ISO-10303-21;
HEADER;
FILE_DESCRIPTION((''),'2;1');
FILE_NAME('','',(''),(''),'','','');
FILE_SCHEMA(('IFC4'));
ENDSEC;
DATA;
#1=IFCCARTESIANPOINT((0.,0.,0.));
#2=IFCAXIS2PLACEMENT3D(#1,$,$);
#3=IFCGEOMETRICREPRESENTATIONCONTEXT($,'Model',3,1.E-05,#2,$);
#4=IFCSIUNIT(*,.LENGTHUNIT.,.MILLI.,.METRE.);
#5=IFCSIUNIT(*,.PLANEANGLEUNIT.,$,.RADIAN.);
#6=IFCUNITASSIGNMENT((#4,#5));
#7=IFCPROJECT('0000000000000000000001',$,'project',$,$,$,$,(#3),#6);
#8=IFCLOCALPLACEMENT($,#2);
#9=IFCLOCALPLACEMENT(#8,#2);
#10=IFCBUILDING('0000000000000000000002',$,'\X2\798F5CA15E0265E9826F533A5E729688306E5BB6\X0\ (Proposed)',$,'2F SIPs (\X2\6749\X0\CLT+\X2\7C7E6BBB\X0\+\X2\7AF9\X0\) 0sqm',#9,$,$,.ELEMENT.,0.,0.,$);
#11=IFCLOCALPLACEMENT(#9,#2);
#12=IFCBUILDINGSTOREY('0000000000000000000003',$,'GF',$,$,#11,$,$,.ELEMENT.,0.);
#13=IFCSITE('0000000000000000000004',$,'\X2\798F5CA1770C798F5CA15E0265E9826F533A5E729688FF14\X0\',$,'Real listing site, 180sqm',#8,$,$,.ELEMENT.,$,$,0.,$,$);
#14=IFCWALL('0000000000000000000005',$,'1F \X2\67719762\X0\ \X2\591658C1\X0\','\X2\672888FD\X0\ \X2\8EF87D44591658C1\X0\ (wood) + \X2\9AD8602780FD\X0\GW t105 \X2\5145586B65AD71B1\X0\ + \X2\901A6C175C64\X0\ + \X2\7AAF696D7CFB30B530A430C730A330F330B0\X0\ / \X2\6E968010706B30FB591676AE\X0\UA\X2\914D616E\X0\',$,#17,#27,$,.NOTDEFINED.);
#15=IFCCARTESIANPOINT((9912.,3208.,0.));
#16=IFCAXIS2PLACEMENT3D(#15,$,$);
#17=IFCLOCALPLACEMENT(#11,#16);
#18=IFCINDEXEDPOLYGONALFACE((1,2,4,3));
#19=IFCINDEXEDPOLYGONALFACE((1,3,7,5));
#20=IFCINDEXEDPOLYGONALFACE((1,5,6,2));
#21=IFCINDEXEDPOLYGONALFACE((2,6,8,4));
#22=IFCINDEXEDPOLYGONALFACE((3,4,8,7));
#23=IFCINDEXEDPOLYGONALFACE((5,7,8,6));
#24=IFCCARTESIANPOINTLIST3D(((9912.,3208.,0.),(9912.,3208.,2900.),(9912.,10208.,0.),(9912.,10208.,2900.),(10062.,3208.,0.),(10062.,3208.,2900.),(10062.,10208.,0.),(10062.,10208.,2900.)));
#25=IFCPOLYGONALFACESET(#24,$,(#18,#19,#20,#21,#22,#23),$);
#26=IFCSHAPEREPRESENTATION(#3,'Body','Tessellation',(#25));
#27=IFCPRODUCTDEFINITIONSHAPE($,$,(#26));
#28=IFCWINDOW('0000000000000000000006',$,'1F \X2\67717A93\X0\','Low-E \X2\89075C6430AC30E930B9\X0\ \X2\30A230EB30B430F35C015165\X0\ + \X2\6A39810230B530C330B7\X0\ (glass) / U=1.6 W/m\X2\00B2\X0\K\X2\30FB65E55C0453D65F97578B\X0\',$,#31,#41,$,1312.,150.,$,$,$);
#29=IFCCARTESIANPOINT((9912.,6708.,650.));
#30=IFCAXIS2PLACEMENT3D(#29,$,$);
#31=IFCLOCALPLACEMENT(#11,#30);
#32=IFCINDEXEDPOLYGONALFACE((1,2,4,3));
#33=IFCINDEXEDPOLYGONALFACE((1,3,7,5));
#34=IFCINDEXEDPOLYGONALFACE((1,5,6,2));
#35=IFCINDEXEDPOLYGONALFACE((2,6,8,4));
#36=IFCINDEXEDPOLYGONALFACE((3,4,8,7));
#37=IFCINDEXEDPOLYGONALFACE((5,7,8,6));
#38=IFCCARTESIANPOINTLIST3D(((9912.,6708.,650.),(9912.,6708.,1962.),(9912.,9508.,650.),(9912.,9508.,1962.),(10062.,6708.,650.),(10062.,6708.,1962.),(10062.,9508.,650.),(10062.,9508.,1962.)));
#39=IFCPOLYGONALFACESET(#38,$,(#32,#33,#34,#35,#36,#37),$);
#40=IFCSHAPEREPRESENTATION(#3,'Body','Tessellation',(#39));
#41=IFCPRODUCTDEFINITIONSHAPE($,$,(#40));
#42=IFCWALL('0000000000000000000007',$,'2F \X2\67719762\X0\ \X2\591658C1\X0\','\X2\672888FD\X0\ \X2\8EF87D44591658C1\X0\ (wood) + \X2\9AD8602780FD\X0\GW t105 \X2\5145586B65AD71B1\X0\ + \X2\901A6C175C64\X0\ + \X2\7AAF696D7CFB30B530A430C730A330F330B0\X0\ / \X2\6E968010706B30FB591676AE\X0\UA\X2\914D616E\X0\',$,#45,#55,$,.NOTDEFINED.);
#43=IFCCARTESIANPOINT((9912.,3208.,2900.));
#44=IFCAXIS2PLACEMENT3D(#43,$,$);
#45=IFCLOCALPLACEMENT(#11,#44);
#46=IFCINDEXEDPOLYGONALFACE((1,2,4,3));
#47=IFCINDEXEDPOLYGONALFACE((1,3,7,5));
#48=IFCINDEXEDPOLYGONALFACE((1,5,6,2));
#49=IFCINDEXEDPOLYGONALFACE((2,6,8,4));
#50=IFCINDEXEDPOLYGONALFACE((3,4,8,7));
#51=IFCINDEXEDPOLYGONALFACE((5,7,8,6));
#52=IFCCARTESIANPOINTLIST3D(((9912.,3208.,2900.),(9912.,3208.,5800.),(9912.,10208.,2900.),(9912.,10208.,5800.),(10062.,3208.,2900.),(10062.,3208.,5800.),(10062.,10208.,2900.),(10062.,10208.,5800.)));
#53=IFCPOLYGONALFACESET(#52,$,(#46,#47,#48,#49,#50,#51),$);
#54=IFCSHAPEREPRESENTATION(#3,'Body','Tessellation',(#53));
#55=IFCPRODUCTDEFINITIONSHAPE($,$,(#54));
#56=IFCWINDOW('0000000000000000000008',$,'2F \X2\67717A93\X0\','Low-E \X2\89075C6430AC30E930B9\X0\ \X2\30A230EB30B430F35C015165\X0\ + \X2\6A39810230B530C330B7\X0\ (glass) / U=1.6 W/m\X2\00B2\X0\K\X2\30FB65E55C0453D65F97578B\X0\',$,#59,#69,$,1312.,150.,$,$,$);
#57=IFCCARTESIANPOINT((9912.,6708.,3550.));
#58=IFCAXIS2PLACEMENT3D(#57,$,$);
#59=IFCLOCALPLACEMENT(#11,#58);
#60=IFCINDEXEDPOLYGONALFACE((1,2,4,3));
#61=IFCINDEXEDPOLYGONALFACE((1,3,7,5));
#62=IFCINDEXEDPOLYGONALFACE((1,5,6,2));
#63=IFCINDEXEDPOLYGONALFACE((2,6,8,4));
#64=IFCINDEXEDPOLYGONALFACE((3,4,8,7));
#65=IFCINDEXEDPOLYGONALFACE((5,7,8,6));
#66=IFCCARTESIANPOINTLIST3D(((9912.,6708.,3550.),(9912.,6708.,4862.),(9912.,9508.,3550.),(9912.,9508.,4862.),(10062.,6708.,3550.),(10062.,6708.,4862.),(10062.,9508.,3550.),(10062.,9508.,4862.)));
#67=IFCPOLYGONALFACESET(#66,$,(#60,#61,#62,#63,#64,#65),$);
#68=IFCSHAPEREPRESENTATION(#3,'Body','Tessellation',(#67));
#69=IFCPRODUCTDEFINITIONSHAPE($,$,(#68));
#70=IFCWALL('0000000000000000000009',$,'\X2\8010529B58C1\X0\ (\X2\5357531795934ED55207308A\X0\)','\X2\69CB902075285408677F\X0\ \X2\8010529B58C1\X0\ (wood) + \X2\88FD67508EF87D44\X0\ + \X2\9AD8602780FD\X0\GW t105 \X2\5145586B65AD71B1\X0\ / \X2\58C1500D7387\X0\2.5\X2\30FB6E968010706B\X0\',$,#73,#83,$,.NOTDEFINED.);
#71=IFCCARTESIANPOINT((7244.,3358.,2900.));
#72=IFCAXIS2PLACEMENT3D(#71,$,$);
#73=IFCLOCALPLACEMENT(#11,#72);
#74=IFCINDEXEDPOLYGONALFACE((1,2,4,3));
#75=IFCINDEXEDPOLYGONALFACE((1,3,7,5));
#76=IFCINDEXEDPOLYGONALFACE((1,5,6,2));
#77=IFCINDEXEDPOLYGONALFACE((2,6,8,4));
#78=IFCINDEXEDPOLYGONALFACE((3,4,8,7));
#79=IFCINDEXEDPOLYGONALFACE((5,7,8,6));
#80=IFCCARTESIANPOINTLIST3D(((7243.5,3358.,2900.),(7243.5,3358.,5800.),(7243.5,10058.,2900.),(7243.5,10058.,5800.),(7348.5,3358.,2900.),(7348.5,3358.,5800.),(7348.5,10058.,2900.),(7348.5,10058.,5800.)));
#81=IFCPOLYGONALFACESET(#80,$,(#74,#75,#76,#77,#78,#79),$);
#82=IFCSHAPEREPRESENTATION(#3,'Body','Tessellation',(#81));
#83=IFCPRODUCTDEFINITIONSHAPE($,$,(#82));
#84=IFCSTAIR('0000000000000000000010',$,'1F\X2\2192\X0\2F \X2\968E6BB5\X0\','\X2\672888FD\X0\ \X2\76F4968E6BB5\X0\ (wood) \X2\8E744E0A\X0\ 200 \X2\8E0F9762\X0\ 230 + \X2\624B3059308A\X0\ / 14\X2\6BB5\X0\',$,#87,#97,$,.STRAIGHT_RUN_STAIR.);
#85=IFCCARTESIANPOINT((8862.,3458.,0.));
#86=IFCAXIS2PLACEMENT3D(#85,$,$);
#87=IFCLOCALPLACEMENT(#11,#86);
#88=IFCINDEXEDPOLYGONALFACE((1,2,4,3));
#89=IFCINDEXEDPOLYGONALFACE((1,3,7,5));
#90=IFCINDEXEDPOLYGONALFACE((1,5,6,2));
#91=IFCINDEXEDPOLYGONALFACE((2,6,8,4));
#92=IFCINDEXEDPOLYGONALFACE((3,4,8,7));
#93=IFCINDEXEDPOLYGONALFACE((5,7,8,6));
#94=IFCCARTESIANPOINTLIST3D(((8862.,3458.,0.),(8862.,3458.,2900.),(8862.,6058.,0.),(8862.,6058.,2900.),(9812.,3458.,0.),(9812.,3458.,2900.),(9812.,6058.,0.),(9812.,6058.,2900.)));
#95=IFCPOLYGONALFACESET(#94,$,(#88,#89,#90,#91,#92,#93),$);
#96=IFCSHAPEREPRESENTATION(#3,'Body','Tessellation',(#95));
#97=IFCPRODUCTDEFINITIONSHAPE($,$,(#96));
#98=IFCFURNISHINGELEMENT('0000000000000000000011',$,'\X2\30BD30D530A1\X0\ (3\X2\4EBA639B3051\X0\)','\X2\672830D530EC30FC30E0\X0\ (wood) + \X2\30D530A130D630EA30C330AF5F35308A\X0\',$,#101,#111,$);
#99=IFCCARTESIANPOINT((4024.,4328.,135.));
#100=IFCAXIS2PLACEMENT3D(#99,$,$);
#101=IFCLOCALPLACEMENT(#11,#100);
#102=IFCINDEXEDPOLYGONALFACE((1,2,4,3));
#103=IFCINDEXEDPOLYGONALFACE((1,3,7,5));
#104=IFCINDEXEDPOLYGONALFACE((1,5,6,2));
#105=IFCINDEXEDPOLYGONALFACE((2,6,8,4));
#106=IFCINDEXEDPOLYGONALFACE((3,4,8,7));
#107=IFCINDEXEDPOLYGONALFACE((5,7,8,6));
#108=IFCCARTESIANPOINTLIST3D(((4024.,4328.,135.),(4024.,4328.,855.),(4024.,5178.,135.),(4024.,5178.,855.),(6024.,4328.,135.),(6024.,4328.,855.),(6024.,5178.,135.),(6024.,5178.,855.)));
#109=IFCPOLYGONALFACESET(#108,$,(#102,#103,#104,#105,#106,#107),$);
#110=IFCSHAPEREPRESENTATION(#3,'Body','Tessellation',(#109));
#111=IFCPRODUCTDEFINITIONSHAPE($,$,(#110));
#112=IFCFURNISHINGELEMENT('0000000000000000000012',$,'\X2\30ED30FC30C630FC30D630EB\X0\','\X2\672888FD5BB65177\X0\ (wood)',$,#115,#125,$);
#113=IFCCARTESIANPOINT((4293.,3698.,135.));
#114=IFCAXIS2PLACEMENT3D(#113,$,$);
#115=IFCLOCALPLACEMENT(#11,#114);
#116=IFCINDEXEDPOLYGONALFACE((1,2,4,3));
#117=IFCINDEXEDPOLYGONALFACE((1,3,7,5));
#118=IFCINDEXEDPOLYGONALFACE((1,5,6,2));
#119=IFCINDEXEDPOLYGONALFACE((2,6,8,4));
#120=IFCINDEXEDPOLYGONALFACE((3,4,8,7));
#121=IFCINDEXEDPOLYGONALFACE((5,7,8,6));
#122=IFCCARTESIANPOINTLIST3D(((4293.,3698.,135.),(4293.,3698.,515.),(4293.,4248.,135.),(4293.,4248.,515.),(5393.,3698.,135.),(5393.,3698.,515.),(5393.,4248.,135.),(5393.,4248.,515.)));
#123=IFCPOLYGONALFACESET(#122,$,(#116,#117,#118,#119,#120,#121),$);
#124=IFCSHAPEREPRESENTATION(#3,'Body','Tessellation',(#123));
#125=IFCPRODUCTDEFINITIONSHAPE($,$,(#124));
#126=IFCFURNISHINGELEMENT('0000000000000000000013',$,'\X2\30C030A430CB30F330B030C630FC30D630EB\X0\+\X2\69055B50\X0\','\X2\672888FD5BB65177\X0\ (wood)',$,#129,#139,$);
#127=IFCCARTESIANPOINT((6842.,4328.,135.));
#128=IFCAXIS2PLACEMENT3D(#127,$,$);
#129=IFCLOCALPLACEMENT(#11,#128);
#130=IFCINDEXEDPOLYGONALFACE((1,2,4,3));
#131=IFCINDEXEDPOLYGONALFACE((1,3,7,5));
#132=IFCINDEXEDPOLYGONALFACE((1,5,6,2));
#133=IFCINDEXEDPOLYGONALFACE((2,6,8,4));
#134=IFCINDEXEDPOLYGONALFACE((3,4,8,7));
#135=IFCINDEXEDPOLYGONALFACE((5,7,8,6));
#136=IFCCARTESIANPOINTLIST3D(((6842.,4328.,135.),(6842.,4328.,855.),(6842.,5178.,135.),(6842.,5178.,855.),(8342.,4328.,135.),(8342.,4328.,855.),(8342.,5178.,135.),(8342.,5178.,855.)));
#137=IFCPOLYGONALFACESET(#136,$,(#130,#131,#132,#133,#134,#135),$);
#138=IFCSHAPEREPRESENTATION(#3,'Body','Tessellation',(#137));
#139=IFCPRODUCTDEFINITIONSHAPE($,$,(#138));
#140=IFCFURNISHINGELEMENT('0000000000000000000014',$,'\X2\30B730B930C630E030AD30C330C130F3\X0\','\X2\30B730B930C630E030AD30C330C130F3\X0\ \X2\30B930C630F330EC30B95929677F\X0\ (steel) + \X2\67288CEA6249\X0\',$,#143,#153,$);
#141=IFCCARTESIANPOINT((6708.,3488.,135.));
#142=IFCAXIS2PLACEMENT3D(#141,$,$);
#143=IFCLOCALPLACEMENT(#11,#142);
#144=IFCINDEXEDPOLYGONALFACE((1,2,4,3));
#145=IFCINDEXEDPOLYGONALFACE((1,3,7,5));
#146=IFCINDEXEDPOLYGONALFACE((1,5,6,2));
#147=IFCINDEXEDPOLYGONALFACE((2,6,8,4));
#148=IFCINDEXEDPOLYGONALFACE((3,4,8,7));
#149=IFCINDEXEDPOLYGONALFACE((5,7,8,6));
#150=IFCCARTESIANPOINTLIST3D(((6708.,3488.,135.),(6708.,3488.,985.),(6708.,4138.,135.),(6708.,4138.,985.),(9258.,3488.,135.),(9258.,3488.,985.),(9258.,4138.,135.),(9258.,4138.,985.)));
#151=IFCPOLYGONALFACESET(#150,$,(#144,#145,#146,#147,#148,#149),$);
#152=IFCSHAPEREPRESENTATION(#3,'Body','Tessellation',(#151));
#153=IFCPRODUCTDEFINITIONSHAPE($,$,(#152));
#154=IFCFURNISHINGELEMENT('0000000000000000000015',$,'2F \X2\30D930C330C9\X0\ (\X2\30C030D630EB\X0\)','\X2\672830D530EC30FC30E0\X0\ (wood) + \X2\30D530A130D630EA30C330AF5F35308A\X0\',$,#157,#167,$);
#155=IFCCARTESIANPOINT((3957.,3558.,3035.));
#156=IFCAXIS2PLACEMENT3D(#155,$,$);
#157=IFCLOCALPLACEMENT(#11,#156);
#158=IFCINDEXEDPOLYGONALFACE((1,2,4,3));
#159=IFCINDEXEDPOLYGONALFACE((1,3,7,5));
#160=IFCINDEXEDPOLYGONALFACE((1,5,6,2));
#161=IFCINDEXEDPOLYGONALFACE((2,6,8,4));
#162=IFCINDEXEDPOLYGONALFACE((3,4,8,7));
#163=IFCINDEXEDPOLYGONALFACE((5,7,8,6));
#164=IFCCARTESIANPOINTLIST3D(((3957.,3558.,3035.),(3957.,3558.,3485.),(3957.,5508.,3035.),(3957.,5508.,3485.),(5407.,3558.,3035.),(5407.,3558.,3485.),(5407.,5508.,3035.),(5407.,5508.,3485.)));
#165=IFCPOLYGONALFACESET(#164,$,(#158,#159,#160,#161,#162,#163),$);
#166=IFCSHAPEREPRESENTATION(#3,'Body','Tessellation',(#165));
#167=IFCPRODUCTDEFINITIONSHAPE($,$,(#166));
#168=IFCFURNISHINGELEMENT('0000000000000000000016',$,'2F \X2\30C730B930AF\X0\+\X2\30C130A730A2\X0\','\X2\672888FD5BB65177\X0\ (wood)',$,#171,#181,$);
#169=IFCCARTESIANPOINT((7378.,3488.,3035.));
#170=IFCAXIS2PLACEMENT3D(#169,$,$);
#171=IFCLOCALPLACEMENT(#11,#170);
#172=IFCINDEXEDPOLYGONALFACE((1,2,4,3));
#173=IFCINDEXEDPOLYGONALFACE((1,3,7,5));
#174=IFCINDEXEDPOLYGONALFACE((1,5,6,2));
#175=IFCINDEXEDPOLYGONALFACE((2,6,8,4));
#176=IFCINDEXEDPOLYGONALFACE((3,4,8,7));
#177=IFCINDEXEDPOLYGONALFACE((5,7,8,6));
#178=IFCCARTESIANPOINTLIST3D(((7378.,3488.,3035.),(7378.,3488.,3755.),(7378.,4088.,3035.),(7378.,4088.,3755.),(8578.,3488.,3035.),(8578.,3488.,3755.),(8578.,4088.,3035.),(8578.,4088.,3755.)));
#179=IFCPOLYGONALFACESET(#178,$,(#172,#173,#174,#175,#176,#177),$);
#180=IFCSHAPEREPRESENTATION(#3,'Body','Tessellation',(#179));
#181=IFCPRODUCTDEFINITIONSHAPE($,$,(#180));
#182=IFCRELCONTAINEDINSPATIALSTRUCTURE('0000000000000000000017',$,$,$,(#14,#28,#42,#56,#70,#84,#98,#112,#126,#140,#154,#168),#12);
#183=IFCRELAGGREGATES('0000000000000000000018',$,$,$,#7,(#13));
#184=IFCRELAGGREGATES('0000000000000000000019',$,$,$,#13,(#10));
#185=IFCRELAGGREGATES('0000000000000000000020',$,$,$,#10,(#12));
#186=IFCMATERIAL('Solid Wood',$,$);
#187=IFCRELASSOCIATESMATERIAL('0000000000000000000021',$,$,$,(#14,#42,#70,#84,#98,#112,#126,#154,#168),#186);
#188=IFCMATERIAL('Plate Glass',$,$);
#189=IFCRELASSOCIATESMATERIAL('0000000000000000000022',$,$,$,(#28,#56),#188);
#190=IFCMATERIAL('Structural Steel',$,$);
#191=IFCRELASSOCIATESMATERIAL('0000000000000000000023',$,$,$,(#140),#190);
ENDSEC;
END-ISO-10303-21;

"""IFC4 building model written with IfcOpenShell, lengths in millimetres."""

from ifc_helpers import new_model, si_unit, frame, frame_2d, origin, place, context, project, spatial, rectangle, extrude, material, element, fill, save


model = new_model("IFC4")

# Units and contexts
model_context = context("Model", 3, precision=1e-05, world=origin())
ifc_project = project(units=[si_unit("LENGTHUNIT", "METRE", prefix="MILLI"), si_unit("PLANEANGLEUNIT", "RADIAN")], contexts=[model_context])

# Site, building, storey
site_placement = place(None, origin())
site = spatial("IfcSite", under=ifc_project, at=site_placement, Name="福岡県福岡市早良区干隈４", ObjectType="Real listing site, 180sqm", CompositionType="ELEMENT", RefElevation=0.0)
building_placement = place(site_placement, origin())
building = spatial("IfcBuilding", under=site, at=building_placement, Name="福岡市早良区干隈の家 (Proposed)", ObjectType="2F SIPs (杉CLT+籾殻+竹) 0sqm", CompositionType="ELEMENT", ElevationOfRefHeight=0.0, ElevationOfTerrain=0.0)
storey_placement = place(building_placement, origin())
storey = spatial("IfcBuildingStorey", under=building, at=storey_placement, Name="GF", CompositionType="ELEMENT", Elevation=0.0)

# Wall, opening, window
ifc_material_1 = material(Name="Solid Wood")
wall_1_placement = place(storey_placement, frame((9912.0, 3208.0, 0.0)))
wall_1 = element("IfcWall", 1, at=wall_1_placement, inside=storey, material=ifc_material_1, Name="1F 東面 外壁", Description="木製 軸組外壁 (wood) + 高性能GW t105 充填断熱 + 通気層 + 窯業系サイディング / 準耐火・外皮UA配慮", PredefinedType="NOTDEFINED", context=model_context, shape_type="SweptSolid", body=[
    extrude(rectangle(XDim=150.0, YDim=7000.0, at=frame_2d((75.0, 3500.0))), frame((9912.0, 3208.0, 0.0)), (0.0, 0.0, 1.0), 2900.0),
])
opening_1_placement = place(storey_placement, frame((9912.0, 6708.0, 650.0)))
opening_1 = element("IfcOpeningElement", 2, at=opening_1_placement, cuts=wall_1, PredefinedType="NOTDEFINED", context=model_context, shape_type="SweptSolid", body=[
    extrude(rectangle(XDim=150.0, YDim=2800.0, at=frame_2d((75.0, 1400.0))), frame((9912.0, 6708.0, 650.0)), (0.0, 0.0, 1.0), 1312.0),
])
ifc_material_2 = material(Name="Plate Glass")
window_1_placement = place(storey_placement, frame((9912.0, 6708.0, 650.0)))
window_1 = element("IfcWindow", 3, at=window_1_placement, inside=storey, material=ifc_material_2, Name="1F 東窓", Description="Low-E 複層ガラス アルゴン封入 + 樹脂サッシ (glass) / U=1.6 W/m²K・日射取得型", OverallHeight=1312.0, OverallWidth=150.0, context=model_context, shape_type="SweptSolid", body=[
    extrude(rectangle(XDim=150.0, YDim=2800.0, at=frame_2d((75.0, 1400.0))), frame((9912.0, 6708.0, 650.0)), (0.0, 0.0, 1.0), 1312.0),
])
fill(opening_1, window_1)

# Wall, opening, window
wall_2_placement = place(storey_placement, frame((9912.0, 3208.0, 2900.0)))
wall_2 = element("IfcWall", 4, at=wall_2_placement, inside=storey, material=ifc_material_1, Name="2F 東面 外壁", Description="木製 軸組外壁 (wood) + 高性能GW t105 充填断熱 + 通気層 + 窯業系サイディング / 準耐火・外皮UA配慮", PredefinedType="NOTDEFINED", context=model_context, shape_type="SweptSolid", body=[
    extrude(rectangle(XDim=150.0, YDim=7000.0, at=frame_2d((75.0, 3500.0))), frame((9912.0, 3208.0, 2900.0)), (0.0, 0.0, 1.0), 2900.0),
])
opening_2_placement = place(storey_placement, frame((9912.0, 6708.0, 3550.0)))
opening_2 = element("IfcOpeningElement", 5, at=opening_2_placement, cuts=wall_2, PredefinedType="NOTDEFINED", context=model_context, shape_type="SweptSolid", body=[
    extrude(rectangle(XDim=150.0, YDim=2800.0, at=frame_2d((75.0, 1400.0))), frame((9912.0, 6708.0, 3550.0)), (0.0, 0.0, 1.0), 1312.0),
])
window_2_placement = place(storey_placement, frame((9912.0, 6708.0, 3550.0)))
window_2 = element("IfcWindow", 6, at=window_2_placement, inside=storey, material=ifc_material_2, Name="2F 東窓", Description="Low-E 複層ガラス アルゴン封入 + 樹脂サッシ (glass) / U=1.6 W/m²K・日射取得型", OverallHeight=1312.0, OverallWidth=150.0, context=model_context, shape_type="SweptSolid", body=[
    extrude(rectangle(XDim=150.0, YDim=2800.0, at=frame_2d((75.0, 1400.0))), frame((9912.0, 6708.0, 3550.0)), (0.0, 0.0, 1.0), 1312.0),
])
fill(opening_2, window_2)

# Wall
wall_3_placement = place(storey_placement, frame((7244.0, 3358.0, 2900.0)))
element("IfcWall", 7, at=wall_3_placement, inside=storey, material=ifc_material_1, Name="耐力壁 (南北間仕切り)", Description="構造用合板 耐力壁 (wood) + 製材軸組 + 高性能GW t105 充填断熱 / 壁倍率2.5・準耐火", PredefinedType="NOTDEFINED", context=model_context, shape_type="SweptSolid", body=[
    extrude(rectangle(XDim=105.0, YDim=6700.0, at=frame_2d((52.0, 3350.0))), frame((7244.0, 3358.0, 2900.0)), (0.0, 0.0, 1.0), 2900.0),
])

# Stair
stair_placement = place(storey_placement, frame((8862.0, 3458.0, 0.0)))
element("IfcStair", 8, at=stair_placement, inside=storey, material=ifc_material_1, Name="1F→2F 階段", Description="木製 直階段 (wood) 蹴上 200 踏面 230 + 手すり / 14段", PredefinedType="STRAIGHT_RUN_STAIR", context=model_context, shape_type="SweptSolid", body=[
    extrude(rectangle(XDim=950.0, YDim=2600.0, at=frame_2d((475.0, 1300.0))), frame((8862.0, 3458.0, 0.0)), (0.0, 0.0, 1.0), 2900.0),
])

# Furnishing elements
furnishing_1_placement = place(storey_placement, frame((4024.0, 4328.0, 135.0)))
element("IfcFurnishingElement", 9, at=furnishing_1_placement, inside=storey, material=ifc_material_1, Name="ソファ (3人掛け)", Description="木フレーム (wood) + ファブリック張り", context=model_context, shape_type="SweptSolid", body=[
    extrude(rectangle(XDim=2000.0, YDim=850.0, at=frame_2d((1000.0, 425.0))), frame((4024.0, 4328.0, 135.0)), (0.0, 0.0, 1.0), 720.0),
])
furnishing_2_placement = place(storey_placement, frame((4293.0, 3698.0, 135.0)))
element("IfcFurnishingElement", 10, at=furnishing_2_placement, inside=storey, material=ifc_material_1, Name="ローテーブル", Description="木製家具 (wood)", context=model_context, shape_type="SweptSolid", body=[
    extrude(rectangle(XDim=1100.0, YDim=550.0, at=frame_2d((550.0, 275.0))), frame((4293.0, 3698.0, 135.0)), (0.0, 0.0, 1.0), 380.0),
])
furnishing_3_placement = place(storey_placement, frame((6842.0, 4328.0, 135.0)))
element("IfcFurnishingElement", 11, at=furnishing_3_placement, inside=storey, material=ifc_material_1, Name="ダイニングテーブル+椅子", Description="木製家具 (wood)", context=model_context, shape_type="SweptSolid", body=[
    extrude(rectangle(XDim=1500.0, YDim=850.0, at=frame_2d((750.0, 425.0))), frame((6842.0, 4328.0, 135.0)), (0.0, 0.0, 1.0), 720.0),
])
ifc_material_3 = material(Name="Structural Steel")
furnishing_4_placement = place(storey_placement, frame((6708.0, 3488.0, 135.0)))
element("IfcFurnishingElement", 12, at=furnishing_4_placement, inside=storey, material=ifc_material_3, Name="システムキッチン", Description="システムキッチン ステンレス天板 (steel) + 木質扉", context=model_context, shape_type="SweptSolid", body=[
    extrude(rectangle(XDim=2550.0, YDim=650.0, at=frame_2d((1275.0, 325.0))), frame((6708.0, 3488.0, 135.0)), (0.0, 0.0, 1.0), 850.0),
])
furnishing_5_placement = place(storey_placement, frame((3957.0, 3558.0, 3035.0)))
element("IfcFurnishingElement", 13, at=furnishing_5_placement, inside=storey, material=ifc_material_1, Name="2F ベッド (ダブル)", Description="木フレーム (wood) + ファブリック張り", context=model_context, shape_type="SweptSolid", body=[
    extrude(rectangle(XDim=1450.0, YDim=1950.0, at=frame_2d((725.0, 975.0))), frame((3957.0, 3558.0, 3035.0)), (0.0, 0.0, 1.0), 450.0),
])
furnishing_6_placement = place(storey_placement, frame((7378.0, 3488.0, 3035.0)))
element("IfcFurnishingElement", 14, at=furnishing_6_placement, inside=storey, material=ifc_material_1, Name="2F デスク+チェア", Description="木製家具 (wood)", context=model_context, shape_type="SweptSolid", body=[
    extrude(rectangle(XDim=1200.0, YDim=600.0, at=frame_2d((600.0, 300.0))), frame((7378.0, 3488.0, 3035.0)), (0.0, 0.0, 1.0), 720.0),
])

save(model, "model.ifc")
